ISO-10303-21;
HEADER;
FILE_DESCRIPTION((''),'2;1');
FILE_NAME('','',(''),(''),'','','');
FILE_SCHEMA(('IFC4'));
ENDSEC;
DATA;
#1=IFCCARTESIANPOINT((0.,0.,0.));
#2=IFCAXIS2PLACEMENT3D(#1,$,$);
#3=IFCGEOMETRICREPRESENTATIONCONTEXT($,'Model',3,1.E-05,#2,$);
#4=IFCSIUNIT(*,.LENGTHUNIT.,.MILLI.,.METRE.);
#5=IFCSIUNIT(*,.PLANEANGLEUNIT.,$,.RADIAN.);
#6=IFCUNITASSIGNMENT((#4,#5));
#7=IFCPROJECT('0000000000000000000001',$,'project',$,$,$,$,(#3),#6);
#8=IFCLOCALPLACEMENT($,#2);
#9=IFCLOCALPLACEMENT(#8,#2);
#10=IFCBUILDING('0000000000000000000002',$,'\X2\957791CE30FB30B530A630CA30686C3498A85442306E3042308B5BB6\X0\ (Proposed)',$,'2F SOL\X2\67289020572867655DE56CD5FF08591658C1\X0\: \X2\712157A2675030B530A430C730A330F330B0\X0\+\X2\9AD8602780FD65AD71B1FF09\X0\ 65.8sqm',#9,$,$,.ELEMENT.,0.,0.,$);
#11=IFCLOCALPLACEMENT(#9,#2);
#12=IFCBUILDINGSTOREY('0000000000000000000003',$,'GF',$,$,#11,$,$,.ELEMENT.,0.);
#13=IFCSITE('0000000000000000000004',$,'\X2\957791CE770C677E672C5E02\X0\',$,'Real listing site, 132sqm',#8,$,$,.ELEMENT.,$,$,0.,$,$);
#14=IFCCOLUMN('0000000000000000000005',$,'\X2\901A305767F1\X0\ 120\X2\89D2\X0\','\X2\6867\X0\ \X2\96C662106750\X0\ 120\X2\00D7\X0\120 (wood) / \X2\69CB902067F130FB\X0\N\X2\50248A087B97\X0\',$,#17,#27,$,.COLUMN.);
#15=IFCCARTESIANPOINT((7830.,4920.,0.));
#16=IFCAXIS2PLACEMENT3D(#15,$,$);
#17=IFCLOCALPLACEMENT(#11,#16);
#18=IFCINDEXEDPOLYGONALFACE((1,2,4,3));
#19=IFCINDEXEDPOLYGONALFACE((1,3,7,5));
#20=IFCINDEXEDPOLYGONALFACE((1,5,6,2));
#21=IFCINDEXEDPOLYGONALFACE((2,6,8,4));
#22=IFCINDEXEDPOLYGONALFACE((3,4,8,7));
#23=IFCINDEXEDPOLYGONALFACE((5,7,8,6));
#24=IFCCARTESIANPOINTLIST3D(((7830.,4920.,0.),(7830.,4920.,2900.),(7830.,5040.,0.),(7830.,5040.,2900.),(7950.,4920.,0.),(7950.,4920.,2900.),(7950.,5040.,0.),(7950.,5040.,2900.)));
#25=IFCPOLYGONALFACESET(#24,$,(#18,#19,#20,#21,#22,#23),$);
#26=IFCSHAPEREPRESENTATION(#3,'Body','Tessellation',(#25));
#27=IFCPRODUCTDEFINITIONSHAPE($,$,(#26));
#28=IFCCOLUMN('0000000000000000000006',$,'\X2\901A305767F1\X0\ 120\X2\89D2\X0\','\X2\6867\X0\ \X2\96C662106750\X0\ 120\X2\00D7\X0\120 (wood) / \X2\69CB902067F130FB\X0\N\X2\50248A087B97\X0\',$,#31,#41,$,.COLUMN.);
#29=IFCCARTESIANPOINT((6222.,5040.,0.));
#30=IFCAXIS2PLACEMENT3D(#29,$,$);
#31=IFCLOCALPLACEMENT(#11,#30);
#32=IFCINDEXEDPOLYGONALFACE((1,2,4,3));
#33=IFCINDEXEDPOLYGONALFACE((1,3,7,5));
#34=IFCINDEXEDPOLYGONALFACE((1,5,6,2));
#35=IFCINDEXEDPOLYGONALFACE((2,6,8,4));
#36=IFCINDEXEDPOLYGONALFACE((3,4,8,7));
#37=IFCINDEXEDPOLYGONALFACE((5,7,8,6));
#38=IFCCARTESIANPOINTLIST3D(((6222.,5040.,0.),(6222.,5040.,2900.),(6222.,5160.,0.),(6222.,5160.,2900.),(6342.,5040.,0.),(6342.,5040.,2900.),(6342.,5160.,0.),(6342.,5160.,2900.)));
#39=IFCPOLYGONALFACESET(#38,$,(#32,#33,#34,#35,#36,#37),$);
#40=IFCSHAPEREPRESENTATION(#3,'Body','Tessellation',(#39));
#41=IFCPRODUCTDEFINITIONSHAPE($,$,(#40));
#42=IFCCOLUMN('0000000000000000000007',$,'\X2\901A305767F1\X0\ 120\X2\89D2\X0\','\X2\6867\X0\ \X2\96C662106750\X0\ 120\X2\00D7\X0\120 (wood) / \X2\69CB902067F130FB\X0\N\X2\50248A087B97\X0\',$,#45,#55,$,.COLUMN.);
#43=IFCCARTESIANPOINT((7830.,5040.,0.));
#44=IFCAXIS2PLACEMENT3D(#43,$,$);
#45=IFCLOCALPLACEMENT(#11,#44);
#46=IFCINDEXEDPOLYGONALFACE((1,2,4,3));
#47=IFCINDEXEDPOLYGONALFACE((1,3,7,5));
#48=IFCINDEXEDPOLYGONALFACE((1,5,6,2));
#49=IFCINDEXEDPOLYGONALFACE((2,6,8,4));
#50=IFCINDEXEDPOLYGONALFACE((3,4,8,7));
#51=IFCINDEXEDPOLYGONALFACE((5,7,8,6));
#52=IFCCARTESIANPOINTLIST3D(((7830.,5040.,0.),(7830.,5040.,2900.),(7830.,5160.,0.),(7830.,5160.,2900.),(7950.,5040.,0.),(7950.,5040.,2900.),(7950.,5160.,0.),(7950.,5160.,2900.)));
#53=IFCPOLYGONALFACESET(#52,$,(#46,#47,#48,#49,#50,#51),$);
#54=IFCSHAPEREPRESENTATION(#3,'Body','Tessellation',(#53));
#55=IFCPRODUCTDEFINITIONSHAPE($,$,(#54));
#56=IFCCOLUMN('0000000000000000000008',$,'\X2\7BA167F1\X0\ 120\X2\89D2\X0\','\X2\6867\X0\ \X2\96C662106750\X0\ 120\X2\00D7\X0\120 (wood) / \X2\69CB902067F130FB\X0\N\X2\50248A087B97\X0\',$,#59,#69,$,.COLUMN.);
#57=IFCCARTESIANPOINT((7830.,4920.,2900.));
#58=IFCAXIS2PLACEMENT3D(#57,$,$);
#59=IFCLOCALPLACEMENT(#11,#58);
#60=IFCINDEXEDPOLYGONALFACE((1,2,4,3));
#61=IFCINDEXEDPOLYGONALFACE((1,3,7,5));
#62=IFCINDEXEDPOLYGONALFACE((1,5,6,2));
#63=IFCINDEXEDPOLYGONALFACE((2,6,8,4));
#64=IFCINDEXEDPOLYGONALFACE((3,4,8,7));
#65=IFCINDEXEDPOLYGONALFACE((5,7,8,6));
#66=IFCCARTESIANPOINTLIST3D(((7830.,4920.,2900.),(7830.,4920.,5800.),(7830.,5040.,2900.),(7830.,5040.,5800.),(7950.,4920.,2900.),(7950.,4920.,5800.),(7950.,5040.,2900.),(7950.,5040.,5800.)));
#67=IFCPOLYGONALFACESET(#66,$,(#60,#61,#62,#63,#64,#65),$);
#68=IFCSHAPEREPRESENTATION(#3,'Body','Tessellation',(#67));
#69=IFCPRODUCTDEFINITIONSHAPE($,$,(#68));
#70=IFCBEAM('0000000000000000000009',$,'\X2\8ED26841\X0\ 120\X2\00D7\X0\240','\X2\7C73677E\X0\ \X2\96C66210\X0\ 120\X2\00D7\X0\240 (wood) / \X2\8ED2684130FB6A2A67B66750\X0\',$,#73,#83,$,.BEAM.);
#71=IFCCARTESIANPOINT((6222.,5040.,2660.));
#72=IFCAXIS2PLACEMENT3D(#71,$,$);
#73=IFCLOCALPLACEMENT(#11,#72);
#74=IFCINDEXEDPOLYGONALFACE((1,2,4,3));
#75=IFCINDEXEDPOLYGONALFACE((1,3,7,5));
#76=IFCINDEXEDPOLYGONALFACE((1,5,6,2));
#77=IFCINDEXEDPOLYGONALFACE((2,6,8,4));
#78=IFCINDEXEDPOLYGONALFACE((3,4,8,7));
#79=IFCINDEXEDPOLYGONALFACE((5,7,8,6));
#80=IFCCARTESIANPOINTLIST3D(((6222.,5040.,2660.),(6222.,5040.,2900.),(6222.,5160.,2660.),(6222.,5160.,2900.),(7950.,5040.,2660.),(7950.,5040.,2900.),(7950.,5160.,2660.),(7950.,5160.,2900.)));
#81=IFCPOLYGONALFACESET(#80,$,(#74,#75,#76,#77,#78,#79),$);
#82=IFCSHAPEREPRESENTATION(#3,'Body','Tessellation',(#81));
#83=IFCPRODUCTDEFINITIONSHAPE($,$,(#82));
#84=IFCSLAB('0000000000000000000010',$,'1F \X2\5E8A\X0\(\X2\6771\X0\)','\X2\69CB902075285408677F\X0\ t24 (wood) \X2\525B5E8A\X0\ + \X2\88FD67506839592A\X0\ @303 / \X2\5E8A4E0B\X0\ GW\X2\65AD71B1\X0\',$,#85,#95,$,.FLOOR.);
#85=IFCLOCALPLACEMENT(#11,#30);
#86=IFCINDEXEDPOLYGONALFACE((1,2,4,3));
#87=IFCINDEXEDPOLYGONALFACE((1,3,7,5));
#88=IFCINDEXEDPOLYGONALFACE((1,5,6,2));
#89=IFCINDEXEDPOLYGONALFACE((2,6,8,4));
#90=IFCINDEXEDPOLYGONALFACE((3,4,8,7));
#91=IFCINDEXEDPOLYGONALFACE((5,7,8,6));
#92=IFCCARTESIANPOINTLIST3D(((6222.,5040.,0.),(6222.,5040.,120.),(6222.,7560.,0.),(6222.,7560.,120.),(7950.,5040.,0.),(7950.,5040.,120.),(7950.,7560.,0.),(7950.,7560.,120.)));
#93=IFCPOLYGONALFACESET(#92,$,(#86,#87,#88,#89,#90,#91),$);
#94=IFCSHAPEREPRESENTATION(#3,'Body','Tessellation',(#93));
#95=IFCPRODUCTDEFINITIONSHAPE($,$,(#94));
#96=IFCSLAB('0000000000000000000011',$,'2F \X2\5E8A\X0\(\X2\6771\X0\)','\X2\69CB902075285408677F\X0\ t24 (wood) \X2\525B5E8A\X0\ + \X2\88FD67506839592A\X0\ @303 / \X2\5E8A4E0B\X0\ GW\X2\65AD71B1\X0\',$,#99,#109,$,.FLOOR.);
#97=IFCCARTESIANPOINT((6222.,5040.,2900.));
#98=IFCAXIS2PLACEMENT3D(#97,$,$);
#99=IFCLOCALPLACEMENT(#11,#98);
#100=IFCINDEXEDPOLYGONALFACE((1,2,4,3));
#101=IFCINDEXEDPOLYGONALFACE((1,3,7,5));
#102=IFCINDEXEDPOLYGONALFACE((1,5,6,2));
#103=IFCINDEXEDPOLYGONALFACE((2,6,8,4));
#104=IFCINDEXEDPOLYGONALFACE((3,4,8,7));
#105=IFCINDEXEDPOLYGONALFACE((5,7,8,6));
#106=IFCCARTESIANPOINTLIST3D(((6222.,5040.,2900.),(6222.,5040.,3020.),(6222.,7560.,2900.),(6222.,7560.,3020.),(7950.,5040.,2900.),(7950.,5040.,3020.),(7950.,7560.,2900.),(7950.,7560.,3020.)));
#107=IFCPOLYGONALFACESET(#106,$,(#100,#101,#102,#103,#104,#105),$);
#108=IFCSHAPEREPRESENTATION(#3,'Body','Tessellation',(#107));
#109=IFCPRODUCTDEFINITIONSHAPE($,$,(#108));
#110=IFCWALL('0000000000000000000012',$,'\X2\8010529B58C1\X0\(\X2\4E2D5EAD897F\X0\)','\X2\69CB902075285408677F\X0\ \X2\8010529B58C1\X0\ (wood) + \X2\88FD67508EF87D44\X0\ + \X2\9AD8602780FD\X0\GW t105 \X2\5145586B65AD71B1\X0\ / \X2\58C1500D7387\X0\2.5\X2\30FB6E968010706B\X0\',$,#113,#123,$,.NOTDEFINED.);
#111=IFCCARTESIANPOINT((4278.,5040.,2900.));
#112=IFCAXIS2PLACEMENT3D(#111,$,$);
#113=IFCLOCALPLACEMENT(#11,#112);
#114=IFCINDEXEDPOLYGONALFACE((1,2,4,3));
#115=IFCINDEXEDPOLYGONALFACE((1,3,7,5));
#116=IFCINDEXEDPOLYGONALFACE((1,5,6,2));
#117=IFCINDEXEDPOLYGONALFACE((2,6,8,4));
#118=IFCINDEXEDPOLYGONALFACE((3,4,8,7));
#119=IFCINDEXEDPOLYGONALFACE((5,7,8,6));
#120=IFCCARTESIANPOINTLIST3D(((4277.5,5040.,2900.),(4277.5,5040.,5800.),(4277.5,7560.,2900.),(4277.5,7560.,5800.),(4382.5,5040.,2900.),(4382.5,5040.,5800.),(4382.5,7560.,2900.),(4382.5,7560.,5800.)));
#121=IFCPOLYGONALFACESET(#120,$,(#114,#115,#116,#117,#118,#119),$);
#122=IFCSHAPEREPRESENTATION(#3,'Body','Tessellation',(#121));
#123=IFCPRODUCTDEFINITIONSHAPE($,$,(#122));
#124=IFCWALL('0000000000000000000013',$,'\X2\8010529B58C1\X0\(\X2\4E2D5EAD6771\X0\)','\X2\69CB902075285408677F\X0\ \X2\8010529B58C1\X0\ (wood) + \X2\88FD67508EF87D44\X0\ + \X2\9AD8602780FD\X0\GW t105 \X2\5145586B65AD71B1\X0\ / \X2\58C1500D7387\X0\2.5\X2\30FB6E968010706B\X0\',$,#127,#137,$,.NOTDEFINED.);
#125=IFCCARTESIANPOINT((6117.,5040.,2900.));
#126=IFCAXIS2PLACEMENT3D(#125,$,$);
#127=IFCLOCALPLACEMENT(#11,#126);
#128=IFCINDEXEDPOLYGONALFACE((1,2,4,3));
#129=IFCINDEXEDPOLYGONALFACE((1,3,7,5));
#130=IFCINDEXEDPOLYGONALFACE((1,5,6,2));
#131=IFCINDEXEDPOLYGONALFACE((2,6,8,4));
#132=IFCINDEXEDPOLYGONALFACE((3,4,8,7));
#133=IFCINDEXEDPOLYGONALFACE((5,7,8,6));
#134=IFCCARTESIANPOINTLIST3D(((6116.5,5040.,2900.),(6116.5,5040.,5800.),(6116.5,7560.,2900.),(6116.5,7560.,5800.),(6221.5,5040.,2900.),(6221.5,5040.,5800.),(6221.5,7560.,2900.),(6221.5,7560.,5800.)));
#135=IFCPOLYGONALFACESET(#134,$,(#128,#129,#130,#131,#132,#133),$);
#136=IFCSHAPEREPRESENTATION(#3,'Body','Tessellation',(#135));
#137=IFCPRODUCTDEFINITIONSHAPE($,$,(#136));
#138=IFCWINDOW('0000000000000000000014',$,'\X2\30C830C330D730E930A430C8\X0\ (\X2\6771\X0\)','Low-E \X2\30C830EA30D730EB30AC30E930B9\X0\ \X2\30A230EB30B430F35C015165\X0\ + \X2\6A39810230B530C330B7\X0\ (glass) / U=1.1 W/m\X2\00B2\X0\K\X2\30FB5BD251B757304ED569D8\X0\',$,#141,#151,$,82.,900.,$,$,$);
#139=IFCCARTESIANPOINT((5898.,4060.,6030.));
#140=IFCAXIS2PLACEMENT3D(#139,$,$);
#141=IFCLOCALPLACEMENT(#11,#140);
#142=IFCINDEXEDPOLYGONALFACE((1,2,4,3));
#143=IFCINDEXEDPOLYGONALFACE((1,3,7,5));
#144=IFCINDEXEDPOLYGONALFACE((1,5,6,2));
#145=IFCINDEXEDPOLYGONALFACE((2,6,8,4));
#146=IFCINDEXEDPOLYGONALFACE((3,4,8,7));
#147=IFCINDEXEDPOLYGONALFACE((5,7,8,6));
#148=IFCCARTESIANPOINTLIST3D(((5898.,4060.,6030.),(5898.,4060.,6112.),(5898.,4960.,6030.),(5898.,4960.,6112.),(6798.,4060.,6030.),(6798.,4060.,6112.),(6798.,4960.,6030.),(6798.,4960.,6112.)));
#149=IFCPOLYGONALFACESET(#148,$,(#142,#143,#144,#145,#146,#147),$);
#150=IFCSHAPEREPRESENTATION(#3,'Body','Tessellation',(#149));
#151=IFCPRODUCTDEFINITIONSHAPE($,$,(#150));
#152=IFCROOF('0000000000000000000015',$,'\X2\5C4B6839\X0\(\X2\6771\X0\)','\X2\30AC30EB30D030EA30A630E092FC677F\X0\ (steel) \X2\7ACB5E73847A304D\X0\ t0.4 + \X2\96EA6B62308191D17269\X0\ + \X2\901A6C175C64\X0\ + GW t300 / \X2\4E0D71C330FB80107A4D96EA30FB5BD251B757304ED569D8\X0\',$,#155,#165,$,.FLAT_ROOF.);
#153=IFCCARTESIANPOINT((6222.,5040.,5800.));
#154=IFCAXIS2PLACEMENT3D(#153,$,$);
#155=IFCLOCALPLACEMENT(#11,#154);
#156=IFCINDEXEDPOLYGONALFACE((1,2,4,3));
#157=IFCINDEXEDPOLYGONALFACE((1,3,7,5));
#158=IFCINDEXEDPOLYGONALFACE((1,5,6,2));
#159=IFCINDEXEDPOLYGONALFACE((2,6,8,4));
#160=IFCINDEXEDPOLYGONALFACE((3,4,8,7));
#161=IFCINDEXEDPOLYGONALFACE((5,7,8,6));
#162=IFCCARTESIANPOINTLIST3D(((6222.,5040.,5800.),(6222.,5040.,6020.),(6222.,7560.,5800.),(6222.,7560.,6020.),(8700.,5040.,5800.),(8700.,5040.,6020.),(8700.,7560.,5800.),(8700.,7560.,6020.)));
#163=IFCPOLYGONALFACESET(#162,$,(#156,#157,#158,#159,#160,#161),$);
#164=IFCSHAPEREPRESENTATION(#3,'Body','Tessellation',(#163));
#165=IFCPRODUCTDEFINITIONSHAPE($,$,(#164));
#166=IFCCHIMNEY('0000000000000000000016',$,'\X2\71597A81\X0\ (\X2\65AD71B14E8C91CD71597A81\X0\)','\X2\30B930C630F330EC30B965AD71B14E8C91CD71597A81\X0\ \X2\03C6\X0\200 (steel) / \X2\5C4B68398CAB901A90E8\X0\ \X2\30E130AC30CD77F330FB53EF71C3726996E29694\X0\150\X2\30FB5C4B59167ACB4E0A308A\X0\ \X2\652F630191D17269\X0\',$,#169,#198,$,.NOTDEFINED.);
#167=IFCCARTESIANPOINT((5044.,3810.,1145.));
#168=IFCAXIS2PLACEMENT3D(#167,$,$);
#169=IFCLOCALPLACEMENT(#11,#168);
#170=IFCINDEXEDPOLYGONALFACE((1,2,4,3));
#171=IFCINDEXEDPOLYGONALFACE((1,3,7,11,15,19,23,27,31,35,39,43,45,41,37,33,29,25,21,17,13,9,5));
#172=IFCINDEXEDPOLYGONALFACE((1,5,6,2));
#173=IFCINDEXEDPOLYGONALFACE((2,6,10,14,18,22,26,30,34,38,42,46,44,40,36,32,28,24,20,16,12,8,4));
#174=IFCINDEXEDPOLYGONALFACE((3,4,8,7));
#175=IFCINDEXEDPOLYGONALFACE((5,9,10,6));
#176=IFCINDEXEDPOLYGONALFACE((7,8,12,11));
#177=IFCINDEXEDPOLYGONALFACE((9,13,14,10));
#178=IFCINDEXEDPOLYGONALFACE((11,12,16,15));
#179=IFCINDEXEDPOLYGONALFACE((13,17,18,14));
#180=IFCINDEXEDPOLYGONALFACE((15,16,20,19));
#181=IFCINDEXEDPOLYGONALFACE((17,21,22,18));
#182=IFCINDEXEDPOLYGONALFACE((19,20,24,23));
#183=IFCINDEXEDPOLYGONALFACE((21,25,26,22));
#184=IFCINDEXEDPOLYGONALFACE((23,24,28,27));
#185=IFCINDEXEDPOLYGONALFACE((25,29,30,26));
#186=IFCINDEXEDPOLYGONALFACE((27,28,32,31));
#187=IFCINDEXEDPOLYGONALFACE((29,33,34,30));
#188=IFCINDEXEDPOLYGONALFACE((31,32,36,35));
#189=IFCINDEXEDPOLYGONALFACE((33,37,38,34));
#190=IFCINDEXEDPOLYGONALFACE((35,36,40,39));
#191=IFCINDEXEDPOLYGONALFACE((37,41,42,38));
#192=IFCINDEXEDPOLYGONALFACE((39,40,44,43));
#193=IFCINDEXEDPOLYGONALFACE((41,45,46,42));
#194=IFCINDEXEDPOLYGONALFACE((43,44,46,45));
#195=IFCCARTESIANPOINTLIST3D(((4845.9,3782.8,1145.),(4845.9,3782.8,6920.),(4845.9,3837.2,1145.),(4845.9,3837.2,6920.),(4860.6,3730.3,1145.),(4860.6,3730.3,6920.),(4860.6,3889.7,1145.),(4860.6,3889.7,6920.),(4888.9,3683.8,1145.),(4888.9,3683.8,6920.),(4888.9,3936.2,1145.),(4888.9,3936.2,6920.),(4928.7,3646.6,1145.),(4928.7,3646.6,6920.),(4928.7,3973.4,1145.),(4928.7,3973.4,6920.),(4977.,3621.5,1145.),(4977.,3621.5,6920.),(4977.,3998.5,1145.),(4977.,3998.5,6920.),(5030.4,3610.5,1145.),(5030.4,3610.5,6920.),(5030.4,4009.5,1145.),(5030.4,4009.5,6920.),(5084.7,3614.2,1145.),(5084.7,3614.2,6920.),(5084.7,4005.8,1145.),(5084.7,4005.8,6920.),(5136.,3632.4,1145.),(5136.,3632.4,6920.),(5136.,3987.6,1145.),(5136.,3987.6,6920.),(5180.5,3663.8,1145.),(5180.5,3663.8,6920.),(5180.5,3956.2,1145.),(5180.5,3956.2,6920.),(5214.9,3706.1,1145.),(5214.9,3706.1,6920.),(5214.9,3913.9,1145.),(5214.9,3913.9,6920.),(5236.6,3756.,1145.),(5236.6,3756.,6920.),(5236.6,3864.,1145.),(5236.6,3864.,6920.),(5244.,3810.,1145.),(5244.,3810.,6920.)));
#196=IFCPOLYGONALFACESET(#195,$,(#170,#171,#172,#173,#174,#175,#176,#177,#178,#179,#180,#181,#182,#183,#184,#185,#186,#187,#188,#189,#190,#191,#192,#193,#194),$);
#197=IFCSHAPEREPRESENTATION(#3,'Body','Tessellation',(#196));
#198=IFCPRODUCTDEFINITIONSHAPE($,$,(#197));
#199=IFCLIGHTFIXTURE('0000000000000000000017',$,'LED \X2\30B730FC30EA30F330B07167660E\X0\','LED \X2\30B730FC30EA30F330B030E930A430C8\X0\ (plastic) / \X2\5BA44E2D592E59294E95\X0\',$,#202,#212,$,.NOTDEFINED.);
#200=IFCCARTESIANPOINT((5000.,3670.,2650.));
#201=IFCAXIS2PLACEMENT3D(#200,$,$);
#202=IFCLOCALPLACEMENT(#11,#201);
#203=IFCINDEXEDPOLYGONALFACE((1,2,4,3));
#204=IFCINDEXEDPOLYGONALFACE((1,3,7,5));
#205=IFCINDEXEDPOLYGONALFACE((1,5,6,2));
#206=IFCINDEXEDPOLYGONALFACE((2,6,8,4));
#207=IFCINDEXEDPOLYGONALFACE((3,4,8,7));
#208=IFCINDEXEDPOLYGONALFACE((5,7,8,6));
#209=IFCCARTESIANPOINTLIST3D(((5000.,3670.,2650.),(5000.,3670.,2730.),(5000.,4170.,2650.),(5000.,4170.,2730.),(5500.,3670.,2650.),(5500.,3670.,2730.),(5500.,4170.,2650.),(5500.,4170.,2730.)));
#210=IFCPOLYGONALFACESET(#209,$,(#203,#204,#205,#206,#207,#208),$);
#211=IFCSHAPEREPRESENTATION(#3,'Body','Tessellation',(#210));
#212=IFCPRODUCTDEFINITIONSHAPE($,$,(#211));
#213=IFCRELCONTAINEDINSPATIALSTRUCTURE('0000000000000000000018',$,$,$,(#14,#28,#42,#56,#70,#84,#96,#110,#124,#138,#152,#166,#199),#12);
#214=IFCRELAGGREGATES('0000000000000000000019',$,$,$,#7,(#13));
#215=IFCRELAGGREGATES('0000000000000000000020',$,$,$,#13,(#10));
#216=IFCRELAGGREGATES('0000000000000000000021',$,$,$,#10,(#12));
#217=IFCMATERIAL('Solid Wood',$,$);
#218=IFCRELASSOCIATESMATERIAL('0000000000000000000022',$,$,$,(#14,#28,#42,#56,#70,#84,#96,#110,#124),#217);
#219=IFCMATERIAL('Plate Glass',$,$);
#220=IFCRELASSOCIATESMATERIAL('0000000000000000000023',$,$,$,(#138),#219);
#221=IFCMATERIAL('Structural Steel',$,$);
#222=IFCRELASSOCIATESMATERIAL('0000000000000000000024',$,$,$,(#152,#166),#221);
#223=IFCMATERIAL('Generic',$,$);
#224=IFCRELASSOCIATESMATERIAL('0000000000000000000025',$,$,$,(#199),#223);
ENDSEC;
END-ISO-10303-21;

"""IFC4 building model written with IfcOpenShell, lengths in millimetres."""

from ifc_helpers import new_model, si_unit, frame, frame_2d, origin, origin_2d, place, context, project, spatial, rectangle, circle, extrude, material, element, save


model = new_model("IFC4")

# Units and contexts
model_context = context("Model", 3, precision=1e-05, world=origin())
ifc_project = project(units=[si_unit("LENGTHUNIT", "METRE", prefix="MILLI"), si_unit("PLANEANGLEUNIT", "RADIAN")], contexts=[model_context])

# Site, building, storey
site_placement = place(None, origin())
site = spatial("IfcSite", under=ifc_project, at=site_placement, Name="長野県松本市", ObjectType="Real listing site, 132sqm", CompositionType="ELEMENT", RefElevation=0.0)
building_placement = place(site_placement, origin())
building = spatial("IfcBuilding", under=site, at=building_placement, Name="長野・サウナと水風呂のある家 (Proposed)", ObjectType="2F SOL木造在来工法（外壁: 無垢材サイディング+高性能断熱） 65.8sqm", CompositionType="ELEMENT", ElevationOfRefHeight=0.0, ElevationOfTerrain=0.0)
storey_placement = place(building_placement, origin())
storey = spatial("IfcBuildingStorey", under=building, at=storey_placement, Name="GF", CompositionType="ELEMENT", Elevation=0.0)

# Columns
ifc_material_1 = material(Name="Solid Wood")
column_1_placement = place(storey_placement, frame((7830.0, 4920.0, 0.0)))
element("IfcColumn", 1, at=column_1_placement, inside=storey, material=ifc_material_1, Name="通し柱 120角", Description="桧 集成材 120×120 (wood) / 構造柱・N値計算", PredefinedType="COLUMN", context=model_context, shape_type="SweptSolid", body=[
    extrude(rectangle(XDim=120.0, YDim=120.0, at=frame_2d((60.0, 60.0))), frame((7830.0, 4920.0, 0.0)), (0.0, 0.0, 1.0), 2900.0),
])
column_2_placement = place(storey_placement, frame((6222.0, 5040.0, 0.0)))
element("IfcColumn", 2, at=column_2_placement, inside=storey, material=ifc_material_1, Name="通し柱 120角", Description="桧 集成材 120×120 (wood) / 構造柱・N値計算", PredefinedType="COLUMN", context=model_context, shape_type="SweptSolid", body=[
    extrude(rectangle(XDim=120.0, YDim=120.0, at=frame_2d((60.0, 60.0))), frame((6222.0, 5040.0, 0.0)), (0.0, 0.0, 1.0), 2900.0),
])
column_3_placement = place(storey_placement, frame((7830.0, 5040.0, 0.0)))
element("IfcColumn", 3, at=column_3_placement, inside=storey, material=ifc_material_1, Name="通し柱 120角", Description="桧 集成材 120×120 (wood) / 構造柱・N値計算", PredefinedType="COLUMN", context=model_context, shape_type="SweptSolid", body=[
    extrude(rectangle(XDim=120.0, YDim=120.0, at=frame_2d((60.0, 60.0))), frame((7830.0, 5040.0, 0.0)), (0.0, 0.0, 1.0), 2900.0),
])
column_4_placement = place(storey_placement, frame((7830.0, 4920.0, 2900.0)))
element("IfcColumn", 4, at=column_4_placement, inside=storey, material=ifc_material_1, Name="管柱 120角", Description="桧 集成材 120×120 (wood) / 構造柱・N値計算", PredefinedType="COLUMN", context=model_context, shape_type="SweptSolid", body=[
    extrude(rectangle(XDim=120.0, YDim=120.0, at=frame_2d((60.0, 60.0))), frame((7830.0, 4920.0, 2900.0)), (0.0, 0.0, 1.0), 2900.0),
])

# Beam
beam_1_placement = place(storey_placement, frame((6222.0, 5040.0, 2660.0)))
element("IfcBeam", 5, at=beam_1_placement, inside=storey, material=ifc_material_1, Name="軒桁 120×240", Description="米松 集成 120×240 (wood) / 軒桁・横架材", PredefinedType="BEAM", context=model_context, shape_type="SweptSolid", body=[
    extrude(rectangle(XDim=1728.0, YDim=120.0, at=frame_2d((864.0, 60.0))), frame((6222.0, 5040.0, 2660.0)), (0.0, 0.0, 1.0), 240.0),
])

# Slabs
slab_1_placement = place(storey_placement, frame((6222.0, 5040.0, 0.0)))
element("IfcSlab", 6, at=slab_1_placement, inside=storey, material=ifc_material_1, Name="1F 床(東)", Description="構造用合板 t24 (wood) 剛床 + 製材根太 @303 / 床下 GW断熱", PredefinedType="FLOOR", context=model_context, shape_type="SweptSolid", body=[
    extrude(rectangle(XDim=1728.0, YDim=2520.0, at=frame_2d((864.0, 1260.0))), frame((6222.0, 5040.0, 0.0)), (0.0, 0.0, 1.0), 120.0),
])
slab_2_placement = place(storey_placement, frame((6222.0, 5040.0, 2900.0)))
element("IfcSlab", 7, at=slab_2_placement, inside=storey, material=ifc_material_1, Name="2F 床(東)", Description="構造用合板 t24 (wood) 剛床 + 製材根太 @303 / 床下 GW断熱", PredefinedType="FLOOR", context=model_context, shape_type="SweptSolid", body=[
    extrude(rectangle(XDim=1728.0, YDim=2520.0, at=frame_2d((864.0, 1260.0))), frame((6222.0, 5040.0, 2900.0)), (0.0, 0.0, 1.0), 120.0),
])

# Walls
wall_1_placement = place(storey_placement, frame((4278.0, 5040.0, 2900.0)))
element("IfcWall", 8, at=wall_1_placement, inside=storey, material=ifc_material_1, Name="耐力壁(中庭西)", Description="構造用合板 耐力壁 (wood) + 製材軸組 + 高性能GW t105 充填断熱 / 壁倍率2.5・準耐火", PredefinedType="NOTDEFINED", context=model_context, shape_type="SweptSolid", body=[
    extrude(rectangle(XDim=105.0, YDim=2520.0, at=frame_2d((52.0, 1260.0))), frame((4278.0, 5040.0, 2900.0)), (0.0, 0.0, 1.0), 2900.0),
])
wall_2_placement = place(storey_placement, frame((6117.0, 5040.0, 2900.0)))
element("IfcWall", 9, at=wall_2_placement, inside=storey, material=ifc_material_1, Name="耐力壁(中庭東)", Description="構造用合板 耐力壁 (wood) + 製材軸組 + 高性能GW t105 充填断熱 / 壁倍率2.5・準耐火", PredefinedType="NOTDEFINED", context=model_context, shape_type="SweptSolid", body=[
    extrude(rectangle(XDim=105.0, YDim=2520.0, at=frame_2d((52.0, 1260.0))), frame((6117.0, 5040.0, 2900.0)), (0.0, 0.0, 1.0), 2900.0),
])

# Window
ifc_material_2 = material(Name="Plate Glass")
window_placement = place(storey_placement, frame((5898.0, 4060.0, 6030.0)))
element("IfcWindow", 10, at=window_placement, inside=storey, material=ifc_material_2, Name="トップライト (東)", Description="Low-E トリプルガラス アルゴン封入 + 樹脂サッシ (glass) / U=1.1 W/m²K・寒冷地仕様", OverallHeight=82.0, OverallWidth=900.0, context=model_context, shape_type="SweptSolid", body=[
    extrude(rectangle(XDim=900.0, YDim=900.0, at=frame_2d((450.0, 450.0))), frame((5898.0, 4060.0, 6030.0)), (0.0, 0.0, 1.0), 82.0),
])

# Roof
ifc_material_3 = material(Name="Structural Steel")
for number, where, name in (
    (11, (6222.0, 5040.0, 5800.0), "屋根(東)"),
):
    element("IfcRoof", number, at=place(storey_placement, frame(where)), inside=storey, material=ifc_material_3, Name=name, Description="ガルバリウム鋼板 (steel) 立平葺き t0.4 + 雪止め金物 + 通気層 + GW t300 / 不燃・耐積雪・寒冷地仕様", PredefinedType="FLAT_ROOF", context=model_context, shape_type="SweptSolid", body=[
        extrude(rectangle(XDim=2478.0, YDim=2520.0, at=frame_2d((1239.0, 1260.0))), frame((6222.0, 5040.0, 5800.0)), (0.0, 0.0, 1.0), 220.0),
    ])

# Chimney
chimney_placement = place(storey_placement, frame((5044.0, 3810.0, 1145.0)))
element("IfcChimney", 12, at=chimney_placement, inside=storey, material=ifc_material_3, Name="煙突 (断熱二重煙突)", Description="ステンレス断熱二重煙突 φ200 (steel) / 屋根貫通部 メガネ石・可燃物離隔150・屋外立上り 支持金物", PredefinedType="NOTDEFINED", context=model_context, shape_type="SweptSolid", body=[
    extrude(circle(Radius=200.0, at=origin_2d()), frame((5044.0, 3810.0, 1145.0)), (0.0, 0.0, 1.0), 5775.0),
])

# Light fixture
ifc_material_4 = material(Name="Generic")
light_fixture_1_placement = place(storey_placement, frame((5000.0, 3670.0, 2650.0)))
element("IfcLightFixture", 13, at=light_fixture_1_placement, inside=storey, material=ifc_material_4, Name="LED シーリング照明", Description="LED シーリングライト (plastic) / 室中央天井", PredefinedType="NOTDEFINED", context=model_context, shape_type="SweptSolid", body=[
    extrude(rectangle(XDim=500.0, YDim=500.0, at=frame_2d((250.0, 250.0))), frame((5000.0, 3670.0, 2650.0)), (0.0, 0.0, 1.0), 80.0),
])

save(model, "model.ifc")
